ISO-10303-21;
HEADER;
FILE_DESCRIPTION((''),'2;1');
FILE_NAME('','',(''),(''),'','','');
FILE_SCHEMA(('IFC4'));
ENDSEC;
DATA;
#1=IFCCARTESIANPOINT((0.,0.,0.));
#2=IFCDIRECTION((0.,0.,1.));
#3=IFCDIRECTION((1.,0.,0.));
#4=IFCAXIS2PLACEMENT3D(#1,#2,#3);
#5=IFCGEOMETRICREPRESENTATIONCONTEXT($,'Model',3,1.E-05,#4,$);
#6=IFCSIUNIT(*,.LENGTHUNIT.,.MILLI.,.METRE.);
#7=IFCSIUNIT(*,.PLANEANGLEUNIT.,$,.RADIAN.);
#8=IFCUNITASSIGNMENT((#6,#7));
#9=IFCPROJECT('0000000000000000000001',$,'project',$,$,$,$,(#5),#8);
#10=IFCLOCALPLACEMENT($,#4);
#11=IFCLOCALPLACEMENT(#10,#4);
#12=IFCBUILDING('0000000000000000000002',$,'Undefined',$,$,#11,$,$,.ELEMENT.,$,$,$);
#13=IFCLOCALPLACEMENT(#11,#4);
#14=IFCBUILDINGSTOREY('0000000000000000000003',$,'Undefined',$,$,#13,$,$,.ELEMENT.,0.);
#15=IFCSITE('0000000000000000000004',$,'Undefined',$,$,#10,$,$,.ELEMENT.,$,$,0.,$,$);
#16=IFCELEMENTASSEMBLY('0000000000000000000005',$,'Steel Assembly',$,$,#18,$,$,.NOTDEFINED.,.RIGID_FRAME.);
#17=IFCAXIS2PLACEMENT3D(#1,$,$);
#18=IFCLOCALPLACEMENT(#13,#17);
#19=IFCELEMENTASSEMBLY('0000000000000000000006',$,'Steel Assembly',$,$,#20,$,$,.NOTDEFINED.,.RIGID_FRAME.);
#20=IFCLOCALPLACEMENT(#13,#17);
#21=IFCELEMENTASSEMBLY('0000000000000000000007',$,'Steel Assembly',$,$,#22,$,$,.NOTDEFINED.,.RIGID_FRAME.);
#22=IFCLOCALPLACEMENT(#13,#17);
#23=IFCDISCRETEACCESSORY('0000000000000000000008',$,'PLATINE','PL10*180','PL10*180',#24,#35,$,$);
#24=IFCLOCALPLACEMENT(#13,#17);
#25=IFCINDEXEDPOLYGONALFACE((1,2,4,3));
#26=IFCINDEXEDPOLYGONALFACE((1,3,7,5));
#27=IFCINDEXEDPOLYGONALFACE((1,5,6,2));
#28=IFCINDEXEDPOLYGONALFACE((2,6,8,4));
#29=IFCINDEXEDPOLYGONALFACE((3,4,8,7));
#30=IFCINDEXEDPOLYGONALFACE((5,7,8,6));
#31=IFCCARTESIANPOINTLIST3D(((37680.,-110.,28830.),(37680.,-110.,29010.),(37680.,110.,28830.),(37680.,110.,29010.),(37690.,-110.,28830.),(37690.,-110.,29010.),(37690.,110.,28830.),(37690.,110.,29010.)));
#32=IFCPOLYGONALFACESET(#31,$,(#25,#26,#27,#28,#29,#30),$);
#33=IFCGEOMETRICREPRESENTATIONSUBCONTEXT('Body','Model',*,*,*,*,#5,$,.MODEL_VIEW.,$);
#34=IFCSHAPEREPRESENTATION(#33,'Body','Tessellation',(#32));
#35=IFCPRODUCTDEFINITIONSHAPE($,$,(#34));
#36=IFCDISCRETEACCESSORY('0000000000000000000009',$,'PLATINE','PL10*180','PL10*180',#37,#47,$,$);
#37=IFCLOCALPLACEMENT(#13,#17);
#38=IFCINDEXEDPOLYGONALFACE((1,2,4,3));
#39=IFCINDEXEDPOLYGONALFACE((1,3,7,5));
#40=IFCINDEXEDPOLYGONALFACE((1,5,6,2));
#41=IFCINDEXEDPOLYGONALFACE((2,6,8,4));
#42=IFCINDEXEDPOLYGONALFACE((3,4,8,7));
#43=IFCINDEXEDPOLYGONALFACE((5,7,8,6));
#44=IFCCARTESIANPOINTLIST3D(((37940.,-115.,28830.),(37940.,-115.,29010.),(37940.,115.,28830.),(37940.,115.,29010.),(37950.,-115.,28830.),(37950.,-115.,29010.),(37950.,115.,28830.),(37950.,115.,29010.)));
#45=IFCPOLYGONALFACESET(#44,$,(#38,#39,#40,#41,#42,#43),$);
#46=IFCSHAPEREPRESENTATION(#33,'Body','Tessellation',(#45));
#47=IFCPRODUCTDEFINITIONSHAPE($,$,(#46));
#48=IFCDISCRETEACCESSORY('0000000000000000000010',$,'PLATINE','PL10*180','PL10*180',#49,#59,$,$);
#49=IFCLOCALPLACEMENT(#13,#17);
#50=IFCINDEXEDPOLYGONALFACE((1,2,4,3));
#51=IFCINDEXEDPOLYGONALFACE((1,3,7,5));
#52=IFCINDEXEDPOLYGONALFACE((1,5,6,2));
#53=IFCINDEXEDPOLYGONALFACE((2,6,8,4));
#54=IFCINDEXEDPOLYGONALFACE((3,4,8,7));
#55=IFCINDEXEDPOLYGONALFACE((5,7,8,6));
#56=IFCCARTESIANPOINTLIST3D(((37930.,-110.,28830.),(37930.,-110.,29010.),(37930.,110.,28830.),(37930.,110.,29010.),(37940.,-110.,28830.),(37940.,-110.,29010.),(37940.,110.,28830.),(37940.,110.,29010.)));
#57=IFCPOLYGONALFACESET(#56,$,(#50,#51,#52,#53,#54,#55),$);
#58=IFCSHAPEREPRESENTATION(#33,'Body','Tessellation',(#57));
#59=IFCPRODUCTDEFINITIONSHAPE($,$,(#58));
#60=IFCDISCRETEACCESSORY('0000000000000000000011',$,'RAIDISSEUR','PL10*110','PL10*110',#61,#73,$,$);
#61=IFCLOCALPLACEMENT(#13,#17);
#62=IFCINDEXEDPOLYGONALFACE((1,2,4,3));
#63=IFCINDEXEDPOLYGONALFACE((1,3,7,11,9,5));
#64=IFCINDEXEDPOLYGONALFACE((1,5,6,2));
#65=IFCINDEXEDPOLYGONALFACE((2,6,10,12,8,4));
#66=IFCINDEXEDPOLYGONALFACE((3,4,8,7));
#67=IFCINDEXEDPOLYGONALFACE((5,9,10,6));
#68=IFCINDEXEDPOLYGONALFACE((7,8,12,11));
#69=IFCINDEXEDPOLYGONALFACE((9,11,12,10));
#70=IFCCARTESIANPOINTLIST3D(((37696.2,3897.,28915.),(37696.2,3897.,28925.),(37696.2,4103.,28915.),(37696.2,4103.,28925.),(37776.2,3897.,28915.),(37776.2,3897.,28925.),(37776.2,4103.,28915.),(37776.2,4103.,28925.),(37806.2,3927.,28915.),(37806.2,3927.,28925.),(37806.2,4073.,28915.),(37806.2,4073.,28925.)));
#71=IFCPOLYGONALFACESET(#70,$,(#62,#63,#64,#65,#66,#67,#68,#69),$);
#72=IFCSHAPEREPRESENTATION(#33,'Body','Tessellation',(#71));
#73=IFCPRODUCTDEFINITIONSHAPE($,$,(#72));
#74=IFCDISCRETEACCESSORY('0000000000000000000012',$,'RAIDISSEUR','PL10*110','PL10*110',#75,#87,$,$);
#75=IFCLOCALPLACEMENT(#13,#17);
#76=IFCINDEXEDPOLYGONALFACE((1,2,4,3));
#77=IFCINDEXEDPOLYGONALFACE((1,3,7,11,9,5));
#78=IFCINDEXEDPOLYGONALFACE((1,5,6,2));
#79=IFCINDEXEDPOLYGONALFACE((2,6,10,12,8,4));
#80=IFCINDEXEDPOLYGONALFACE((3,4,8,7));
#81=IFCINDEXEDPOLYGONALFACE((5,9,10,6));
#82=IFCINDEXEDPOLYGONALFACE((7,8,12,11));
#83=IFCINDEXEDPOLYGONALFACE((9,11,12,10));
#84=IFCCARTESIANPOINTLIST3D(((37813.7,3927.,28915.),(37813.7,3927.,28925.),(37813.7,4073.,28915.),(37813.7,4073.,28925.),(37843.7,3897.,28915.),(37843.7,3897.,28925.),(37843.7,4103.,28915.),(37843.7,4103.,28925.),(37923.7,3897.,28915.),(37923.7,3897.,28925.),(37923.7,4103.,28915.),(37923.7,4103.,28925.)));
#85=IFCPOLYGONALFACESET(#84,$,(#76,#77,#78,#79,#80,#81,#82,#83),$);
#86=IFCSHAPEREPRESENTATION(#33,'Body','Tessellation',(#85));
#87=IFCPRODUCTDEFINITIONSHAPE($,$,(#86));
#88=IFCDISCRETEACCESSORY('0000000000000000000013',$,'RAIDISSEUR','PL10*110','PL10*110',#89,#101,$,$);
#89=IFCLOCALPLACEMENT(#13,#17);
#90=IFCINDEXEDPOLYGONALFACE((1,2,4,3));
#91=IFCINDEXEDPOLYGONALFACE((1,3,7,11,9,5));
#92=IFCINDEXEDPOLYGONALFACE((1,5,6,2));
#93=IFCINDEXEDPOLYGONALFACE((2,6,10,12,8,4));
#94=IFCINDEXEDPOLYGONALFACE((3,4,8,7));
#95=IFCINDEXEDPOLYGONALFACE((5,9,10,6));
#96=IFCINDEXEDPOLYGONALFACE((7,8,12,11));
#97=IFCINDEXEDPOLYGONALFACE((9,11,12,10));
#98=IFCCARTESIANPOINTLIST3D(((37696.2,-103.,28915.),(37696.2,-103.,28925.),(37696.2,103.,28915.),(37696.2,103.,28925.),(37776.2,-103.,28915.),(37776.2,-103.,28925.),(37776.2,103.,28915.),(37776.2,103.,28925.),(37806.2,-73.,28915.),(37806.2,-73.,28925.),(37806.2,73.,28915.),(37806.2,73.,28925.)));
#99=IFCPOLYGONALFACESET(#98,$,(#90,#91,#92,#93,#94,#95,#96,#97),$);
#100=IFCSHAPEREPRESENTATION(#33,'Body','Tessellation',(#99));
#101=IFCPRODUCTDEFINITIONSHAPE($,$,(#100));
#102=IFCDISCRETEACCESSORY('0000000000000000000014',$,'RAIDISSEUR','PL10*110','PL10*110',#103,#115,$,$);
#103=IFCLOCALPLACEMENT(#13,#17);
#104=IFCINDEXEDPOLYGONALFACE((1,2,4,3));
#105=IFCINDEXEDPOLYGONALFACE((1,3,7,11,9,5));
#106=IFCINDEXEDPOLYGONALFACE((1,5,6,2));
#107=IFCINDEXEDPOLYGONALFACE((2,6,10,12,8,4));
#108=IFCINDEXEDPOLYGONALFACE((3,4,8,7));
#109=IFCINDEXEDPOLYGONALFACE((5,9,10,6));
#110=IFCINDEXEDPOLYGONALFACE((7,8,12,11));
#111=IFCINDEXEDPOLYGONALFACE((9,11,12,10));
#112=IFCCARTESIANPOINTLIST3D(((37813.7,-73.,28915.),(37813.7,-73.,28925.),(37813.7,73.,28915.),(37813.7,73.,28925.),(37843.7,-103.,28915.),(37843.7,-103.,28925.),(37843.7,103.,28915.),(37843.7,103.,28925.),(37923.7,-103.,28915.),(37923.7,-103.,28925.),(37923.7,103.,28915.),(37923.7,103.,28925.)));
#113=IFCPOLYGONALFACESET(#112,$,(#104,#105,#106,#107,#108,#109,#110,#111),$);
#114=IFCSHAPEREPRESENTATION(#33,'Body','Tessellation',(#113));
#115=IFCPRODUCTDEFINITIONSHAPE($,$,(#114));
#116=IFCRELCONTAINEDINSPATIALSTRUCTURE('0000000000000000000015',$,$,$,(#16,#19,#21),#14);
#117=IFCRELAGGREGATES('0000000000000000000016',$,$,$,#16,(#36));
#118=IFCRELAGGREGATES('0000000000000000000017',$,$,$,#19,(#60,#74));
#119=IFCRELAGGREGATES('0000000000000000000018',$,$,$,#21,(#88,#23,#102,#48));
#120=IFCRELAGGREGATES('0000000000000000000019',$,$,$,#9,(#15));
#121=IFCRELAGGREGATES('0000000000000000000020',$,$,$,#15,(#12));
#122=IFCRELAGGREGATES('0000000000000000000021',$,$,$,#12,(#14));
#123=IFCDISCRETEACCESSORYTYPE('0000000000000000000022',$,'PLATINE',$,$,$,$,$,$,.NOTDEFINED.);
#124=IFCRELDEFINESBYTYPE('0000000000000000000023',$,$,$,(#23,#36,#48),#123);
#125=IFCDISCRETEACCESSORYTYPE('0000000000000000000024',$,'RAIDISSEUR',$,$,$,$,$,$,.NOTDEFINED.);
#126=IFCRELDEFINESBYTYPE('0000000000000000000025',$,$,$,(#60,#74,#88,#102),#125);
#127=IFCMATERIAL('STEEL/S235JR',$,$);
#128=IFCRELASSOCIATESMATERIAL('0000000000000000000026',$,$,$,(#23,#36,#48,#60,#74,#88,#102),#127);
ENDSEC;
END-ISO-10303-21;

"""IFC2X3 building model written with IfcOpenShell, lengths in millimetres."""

from ifc_helpers import new_model, si_unit, frame, origin_with_axes, place, context, subcontext, project, spatial, polyline, outline, extrude, material, type_object, element, aggregate, save


model = new_model("IFC2X3")

# Units and contexts
model_context = context("Model", 3, precision=1e-05, world=origin_with_axes())
body_context = subcontext(model_context, "Body", "Model", "MODEL_VIEW")
ifc_project = project(units=[si_unit("LENGTHUNIT", "METRE", prefix="MILLI"), si_unit("PLANEANGLEUNIT", "RADIAN")], contexts=[model_context])

# Site, building, storey
site_placement = place(None, origin_with_axes())
site = spatial("IfcSite", under=ifc_project, at=site_placement, Name="Undefined", CompositionType="ELEMENT", RefElevation=0.0)
building_placement = place(site_placement, origin_with_axes())
building = spatial("IfcBuilding", under=site, at=building_placement, Name="Undefined", CompositionType="ELEMENT")
storey_placement = place(building_placement, origin_with_axes())
storey = spatial("IfcBuildingStorey", under=building, at=storey_placement, Name="Undefined", CompositionType="ELEMENT", Elevation=0.0)

# Shared definitions
ifc_material_1 = material(Name="STEEL/S235JR")

# Element assembly
assembly_1_placement = place(storey_placement, origin_with_axes())
assembly_1 = element("IfcElementAssembly", 1, at=assembly_1_placement, inside=storey, Name="Steel Assembly", AssemblyPlace="NOTDEFINED", PredefinedType="RIGID_FRAME")

# Element assembly
assembly_2_placement = place(storey_placement, origin_with_axes())
assembly_2 = element("IfcElementAssembly", 2, at=assembly_2_placement, inside=storey, Name="Steel Assembly", AssemblyPlace="NOTDEFINED", PredefinedType="RIGID_FRAME")
discrete_accessory_type_1 = type_object("IfcDiscreteAccessoryType", Name="PLATINE")

# Element assembly, discrete accessory
assembly_3_placement = place(storey_placement, origin_with_axes())
assembly_3 = element("IfcElementAssembly", 3, at=assembly_3_placement, inside=storey, Name="Steel Assembly", AssemblyPlace="NOTDEFINED", PredefinedType="RIGID_FRAME")
discrete_accessory_1_placement = place(assembly_3_placement, frame((37685.0, 110.0, 28920.0), z_axis=(-1.0, 0.0, 0.0), x_axis=(0.0, -1.0, 0.0)))
discrete_accessory_1 = element("IfcDiscreteAccessory", 4, at=discrete_accessory_1_placement, type_object=discrete_accessory_type_1, material=ifc_material_1, Name="PLATINE", Description="PL10*180", ObjectType="PL10*180", context=body_context, shape_type="SweptSolid", body=[
    extrude(outline(polyline([(0.0, -90.0), (0.0, 90.0), (220.0, 90.0), (220.0, -90.0), (0.0, -90.0)])), frame((0.0, 0.0, -5.0), z_axis=(0.0, 0.0, 1.0), x_axis=(1.0, 0.0, 0.0)), (0.0, 0.0, 1.0), 10.0),
])

# Discrete accessories
discrete_accessory_2_placement = place(assembly_1_placement, frame((37945.0, 115.0, 28920.0), z_axis=(1.0, 0.0, 0.0), x_axis=(0.0, -1.0, 0.0)))
discrete_accessory_2 = element("IfcDiscreteAccessory", 5, at=discrete_accessory_2_placement, type_object=discrete_accessory_type_1, material=ifc_material_1, Name="PLATINE", Description="PL10*180", ObjectType="PL10*180", context=body_context, shape_type="SweptSolid", body=[
    extrude(outline(polyline([(230.0, -90.0), (0.0, -90.0), (0.0, 90.0), (230.0, 90.0), (230.0, -90.0)])), frame((0.0, 0.0, -5.0), z_axis=(0.0, 0.0, 1.0), x_axis=(1.0, 0.0, 0.0)), (0.0, 0.0, 1.0), 10.0),
])
aggregate(assembly_1, [discrete_accessory_2])
discrete_accessory_3_placement = place(assembly_3_placement, frame((37935.0, 110.0, 28920.0), z_axis=(1.0, 0.0, 0.0), x_axis=(0.0, -1.0, 0.0)))
discrete_accessory_3 = element("IfcDiscreteAccessory", 6, at=discrete_accessory_3_placement, type_object=discrete_accessory_type_1, material=ifc_material_1, Name="PLATINE", Description="PL10*180", ObjectType="PL10*180", context=body_context, shape_type="SweptSolid", body=[
    extrude(outline(polyline([(220.0, -90.0), (0.0, -90.0), (0.0, 90.0), (220.0, 90.0), (220.0, -90.0)])), frame((0.0, 0.0, -5.0), z_axis=(0.0, 0.0, 1.0), x_axis=(1.0, 0.0, 0.0)), (0.0, 0.0, 1.0), 10.0),
])
discrete_accessory_type_2 = type_object("IfcDiscreteAccessoryType", Name="RAIDISSEUR")
discrete_accessory_4_placement = place(assembly_2_placement, frame((37806.2, 4103.0, 28920.0), z_axis=(0.0, 0.0, 1.0), x_axis=(-1.0, 0.0, 0.0)))
discrete_accessory_4 = element("IfcDiscreteAccessory", 7, at=discrete_accessory_4_placement, type_object=discrete_accessory_type_2, material=ifc_material_1, Name="RAIDISSEUR", Description="PL10*110", ObjectType="PL10*110", context=body_context, shape_type="SweptSolid", body=[
    extrude(outline(polyline([(0.0, 30.0), (30.0, 0.0), (110.0, 0.0), (110.0, 206.0), (30.0, 206.0), (0.0, 176.0), (0.0, 30.0)])), frame((0.0, 0.0, -5.0), z_axis=(0.0, 0.0, 1.0), x_axis=(1.0, 0.0, 0.0)), (0.0, 0.0, 1.0), 10.0),
])
discrete_accessory_5_placement = place(assembly_2_placement, frame((37813.7, 4103.0, 28920.0), z_axis=(0.0, 0.0, -1.0), x_axis=(1.0, 0.0, 0.0)))
discrete_accessory_5 = element("IfcDiscreteAccessory", 8, at=discrete_accessory_5_placement, type_object=discrete_accessory_type_2, material=ifc_material_1, Name="RAIDISSEUR", Description="PL10*110", ObjectType="PL10*110", context=body_context, shape_type="SweptSolid", body=[
    extrude(outline(polyline([(0.0, 30.0), (30.0, 0.0), (110.0, 0.0), (110.0, 206.0), (30.0, 206.0), (0.0, 176.0), (0.0, 30.0)])), frame((0.0, 0.0, -5.0), z_axis=(0.0, 0.0, 1.0), x_axis=(1.0, 0.0, 0.0)), (0.0, 0.0, 1.0), 10.0),
])
aggregate(assembly_2, [discrete_accessory_4, discrete_accessory_5])
discrete_accessory_6_placement = place(assembly_3_placement, frame((37806.2, 103.0, 28920.0), z_axis=(0.0, 0.0, 1.0), x_axis=(-1.0, 0.0, 0.0)))
discrete_accessory_6 = element("IfcDiscreteAccessory", 9, at=discrete_accessory_6_placement, type_object=discrete_accessory_type_2, material=ifc_material_1, Name="RAIDISSEUR", Description="PL10*110", ObjectType="PL10*110", context=body_context, shape_type="SweptSolid", body=[
    extrude(outline(polyline([(0.0, 30.0), (30.0, 0.0), (110.0, 0.0), (110.0, 206.0), (30.0, 206.0), (0.0, 176.0), (0.0, 30.0)])), frame((0.0, 0.0, -5.0), z_axis=(0.0, 0.0, 1.0), x_axis=(1.0, 0.0, 0.0)), (0.0, 0.0, 1.0), 10.0),
])
discrete_accessory_7_placement = place(assembly_3_placement, frame((37813.7, 103.0, 28920.0), z_axis=(0.0, 0.0, -1.0), x_axis=(1.0, 0.0, 0.0)))
discrete_accessory_7 = element("IfcDiscreteAccessory", 10, at=discrete_accessory_7_placement, type_object=discrete_accessory_type_2, material=ifc_material_1, Name="RAIDISSEUR", Description="PL10*110", ObjectType="PL10*110", context=body_context, shape_type="SweptSolid", body=[
    extrude(outline(polyline([(0.0, 30.0), (30.0, 0.0), (110.0, 0.0), (110.0, 206.0), (30.0, 206.0), (0.0, 176.0), (0.0, 30.0)])), frame((0.0, 0.0, -5.0), z_axis=(0.0, 0.0, 1.0), x_axis=(1.0, 0.0, 0.0)), (0.0, 0.0, 1.0), 10.0),
])
aggregate(assembly_3, [discrete_accessory_6, discrete_accessory_1, discrete_accessory_7, discrete_accessory_3])

save(model, "model.ifc")
